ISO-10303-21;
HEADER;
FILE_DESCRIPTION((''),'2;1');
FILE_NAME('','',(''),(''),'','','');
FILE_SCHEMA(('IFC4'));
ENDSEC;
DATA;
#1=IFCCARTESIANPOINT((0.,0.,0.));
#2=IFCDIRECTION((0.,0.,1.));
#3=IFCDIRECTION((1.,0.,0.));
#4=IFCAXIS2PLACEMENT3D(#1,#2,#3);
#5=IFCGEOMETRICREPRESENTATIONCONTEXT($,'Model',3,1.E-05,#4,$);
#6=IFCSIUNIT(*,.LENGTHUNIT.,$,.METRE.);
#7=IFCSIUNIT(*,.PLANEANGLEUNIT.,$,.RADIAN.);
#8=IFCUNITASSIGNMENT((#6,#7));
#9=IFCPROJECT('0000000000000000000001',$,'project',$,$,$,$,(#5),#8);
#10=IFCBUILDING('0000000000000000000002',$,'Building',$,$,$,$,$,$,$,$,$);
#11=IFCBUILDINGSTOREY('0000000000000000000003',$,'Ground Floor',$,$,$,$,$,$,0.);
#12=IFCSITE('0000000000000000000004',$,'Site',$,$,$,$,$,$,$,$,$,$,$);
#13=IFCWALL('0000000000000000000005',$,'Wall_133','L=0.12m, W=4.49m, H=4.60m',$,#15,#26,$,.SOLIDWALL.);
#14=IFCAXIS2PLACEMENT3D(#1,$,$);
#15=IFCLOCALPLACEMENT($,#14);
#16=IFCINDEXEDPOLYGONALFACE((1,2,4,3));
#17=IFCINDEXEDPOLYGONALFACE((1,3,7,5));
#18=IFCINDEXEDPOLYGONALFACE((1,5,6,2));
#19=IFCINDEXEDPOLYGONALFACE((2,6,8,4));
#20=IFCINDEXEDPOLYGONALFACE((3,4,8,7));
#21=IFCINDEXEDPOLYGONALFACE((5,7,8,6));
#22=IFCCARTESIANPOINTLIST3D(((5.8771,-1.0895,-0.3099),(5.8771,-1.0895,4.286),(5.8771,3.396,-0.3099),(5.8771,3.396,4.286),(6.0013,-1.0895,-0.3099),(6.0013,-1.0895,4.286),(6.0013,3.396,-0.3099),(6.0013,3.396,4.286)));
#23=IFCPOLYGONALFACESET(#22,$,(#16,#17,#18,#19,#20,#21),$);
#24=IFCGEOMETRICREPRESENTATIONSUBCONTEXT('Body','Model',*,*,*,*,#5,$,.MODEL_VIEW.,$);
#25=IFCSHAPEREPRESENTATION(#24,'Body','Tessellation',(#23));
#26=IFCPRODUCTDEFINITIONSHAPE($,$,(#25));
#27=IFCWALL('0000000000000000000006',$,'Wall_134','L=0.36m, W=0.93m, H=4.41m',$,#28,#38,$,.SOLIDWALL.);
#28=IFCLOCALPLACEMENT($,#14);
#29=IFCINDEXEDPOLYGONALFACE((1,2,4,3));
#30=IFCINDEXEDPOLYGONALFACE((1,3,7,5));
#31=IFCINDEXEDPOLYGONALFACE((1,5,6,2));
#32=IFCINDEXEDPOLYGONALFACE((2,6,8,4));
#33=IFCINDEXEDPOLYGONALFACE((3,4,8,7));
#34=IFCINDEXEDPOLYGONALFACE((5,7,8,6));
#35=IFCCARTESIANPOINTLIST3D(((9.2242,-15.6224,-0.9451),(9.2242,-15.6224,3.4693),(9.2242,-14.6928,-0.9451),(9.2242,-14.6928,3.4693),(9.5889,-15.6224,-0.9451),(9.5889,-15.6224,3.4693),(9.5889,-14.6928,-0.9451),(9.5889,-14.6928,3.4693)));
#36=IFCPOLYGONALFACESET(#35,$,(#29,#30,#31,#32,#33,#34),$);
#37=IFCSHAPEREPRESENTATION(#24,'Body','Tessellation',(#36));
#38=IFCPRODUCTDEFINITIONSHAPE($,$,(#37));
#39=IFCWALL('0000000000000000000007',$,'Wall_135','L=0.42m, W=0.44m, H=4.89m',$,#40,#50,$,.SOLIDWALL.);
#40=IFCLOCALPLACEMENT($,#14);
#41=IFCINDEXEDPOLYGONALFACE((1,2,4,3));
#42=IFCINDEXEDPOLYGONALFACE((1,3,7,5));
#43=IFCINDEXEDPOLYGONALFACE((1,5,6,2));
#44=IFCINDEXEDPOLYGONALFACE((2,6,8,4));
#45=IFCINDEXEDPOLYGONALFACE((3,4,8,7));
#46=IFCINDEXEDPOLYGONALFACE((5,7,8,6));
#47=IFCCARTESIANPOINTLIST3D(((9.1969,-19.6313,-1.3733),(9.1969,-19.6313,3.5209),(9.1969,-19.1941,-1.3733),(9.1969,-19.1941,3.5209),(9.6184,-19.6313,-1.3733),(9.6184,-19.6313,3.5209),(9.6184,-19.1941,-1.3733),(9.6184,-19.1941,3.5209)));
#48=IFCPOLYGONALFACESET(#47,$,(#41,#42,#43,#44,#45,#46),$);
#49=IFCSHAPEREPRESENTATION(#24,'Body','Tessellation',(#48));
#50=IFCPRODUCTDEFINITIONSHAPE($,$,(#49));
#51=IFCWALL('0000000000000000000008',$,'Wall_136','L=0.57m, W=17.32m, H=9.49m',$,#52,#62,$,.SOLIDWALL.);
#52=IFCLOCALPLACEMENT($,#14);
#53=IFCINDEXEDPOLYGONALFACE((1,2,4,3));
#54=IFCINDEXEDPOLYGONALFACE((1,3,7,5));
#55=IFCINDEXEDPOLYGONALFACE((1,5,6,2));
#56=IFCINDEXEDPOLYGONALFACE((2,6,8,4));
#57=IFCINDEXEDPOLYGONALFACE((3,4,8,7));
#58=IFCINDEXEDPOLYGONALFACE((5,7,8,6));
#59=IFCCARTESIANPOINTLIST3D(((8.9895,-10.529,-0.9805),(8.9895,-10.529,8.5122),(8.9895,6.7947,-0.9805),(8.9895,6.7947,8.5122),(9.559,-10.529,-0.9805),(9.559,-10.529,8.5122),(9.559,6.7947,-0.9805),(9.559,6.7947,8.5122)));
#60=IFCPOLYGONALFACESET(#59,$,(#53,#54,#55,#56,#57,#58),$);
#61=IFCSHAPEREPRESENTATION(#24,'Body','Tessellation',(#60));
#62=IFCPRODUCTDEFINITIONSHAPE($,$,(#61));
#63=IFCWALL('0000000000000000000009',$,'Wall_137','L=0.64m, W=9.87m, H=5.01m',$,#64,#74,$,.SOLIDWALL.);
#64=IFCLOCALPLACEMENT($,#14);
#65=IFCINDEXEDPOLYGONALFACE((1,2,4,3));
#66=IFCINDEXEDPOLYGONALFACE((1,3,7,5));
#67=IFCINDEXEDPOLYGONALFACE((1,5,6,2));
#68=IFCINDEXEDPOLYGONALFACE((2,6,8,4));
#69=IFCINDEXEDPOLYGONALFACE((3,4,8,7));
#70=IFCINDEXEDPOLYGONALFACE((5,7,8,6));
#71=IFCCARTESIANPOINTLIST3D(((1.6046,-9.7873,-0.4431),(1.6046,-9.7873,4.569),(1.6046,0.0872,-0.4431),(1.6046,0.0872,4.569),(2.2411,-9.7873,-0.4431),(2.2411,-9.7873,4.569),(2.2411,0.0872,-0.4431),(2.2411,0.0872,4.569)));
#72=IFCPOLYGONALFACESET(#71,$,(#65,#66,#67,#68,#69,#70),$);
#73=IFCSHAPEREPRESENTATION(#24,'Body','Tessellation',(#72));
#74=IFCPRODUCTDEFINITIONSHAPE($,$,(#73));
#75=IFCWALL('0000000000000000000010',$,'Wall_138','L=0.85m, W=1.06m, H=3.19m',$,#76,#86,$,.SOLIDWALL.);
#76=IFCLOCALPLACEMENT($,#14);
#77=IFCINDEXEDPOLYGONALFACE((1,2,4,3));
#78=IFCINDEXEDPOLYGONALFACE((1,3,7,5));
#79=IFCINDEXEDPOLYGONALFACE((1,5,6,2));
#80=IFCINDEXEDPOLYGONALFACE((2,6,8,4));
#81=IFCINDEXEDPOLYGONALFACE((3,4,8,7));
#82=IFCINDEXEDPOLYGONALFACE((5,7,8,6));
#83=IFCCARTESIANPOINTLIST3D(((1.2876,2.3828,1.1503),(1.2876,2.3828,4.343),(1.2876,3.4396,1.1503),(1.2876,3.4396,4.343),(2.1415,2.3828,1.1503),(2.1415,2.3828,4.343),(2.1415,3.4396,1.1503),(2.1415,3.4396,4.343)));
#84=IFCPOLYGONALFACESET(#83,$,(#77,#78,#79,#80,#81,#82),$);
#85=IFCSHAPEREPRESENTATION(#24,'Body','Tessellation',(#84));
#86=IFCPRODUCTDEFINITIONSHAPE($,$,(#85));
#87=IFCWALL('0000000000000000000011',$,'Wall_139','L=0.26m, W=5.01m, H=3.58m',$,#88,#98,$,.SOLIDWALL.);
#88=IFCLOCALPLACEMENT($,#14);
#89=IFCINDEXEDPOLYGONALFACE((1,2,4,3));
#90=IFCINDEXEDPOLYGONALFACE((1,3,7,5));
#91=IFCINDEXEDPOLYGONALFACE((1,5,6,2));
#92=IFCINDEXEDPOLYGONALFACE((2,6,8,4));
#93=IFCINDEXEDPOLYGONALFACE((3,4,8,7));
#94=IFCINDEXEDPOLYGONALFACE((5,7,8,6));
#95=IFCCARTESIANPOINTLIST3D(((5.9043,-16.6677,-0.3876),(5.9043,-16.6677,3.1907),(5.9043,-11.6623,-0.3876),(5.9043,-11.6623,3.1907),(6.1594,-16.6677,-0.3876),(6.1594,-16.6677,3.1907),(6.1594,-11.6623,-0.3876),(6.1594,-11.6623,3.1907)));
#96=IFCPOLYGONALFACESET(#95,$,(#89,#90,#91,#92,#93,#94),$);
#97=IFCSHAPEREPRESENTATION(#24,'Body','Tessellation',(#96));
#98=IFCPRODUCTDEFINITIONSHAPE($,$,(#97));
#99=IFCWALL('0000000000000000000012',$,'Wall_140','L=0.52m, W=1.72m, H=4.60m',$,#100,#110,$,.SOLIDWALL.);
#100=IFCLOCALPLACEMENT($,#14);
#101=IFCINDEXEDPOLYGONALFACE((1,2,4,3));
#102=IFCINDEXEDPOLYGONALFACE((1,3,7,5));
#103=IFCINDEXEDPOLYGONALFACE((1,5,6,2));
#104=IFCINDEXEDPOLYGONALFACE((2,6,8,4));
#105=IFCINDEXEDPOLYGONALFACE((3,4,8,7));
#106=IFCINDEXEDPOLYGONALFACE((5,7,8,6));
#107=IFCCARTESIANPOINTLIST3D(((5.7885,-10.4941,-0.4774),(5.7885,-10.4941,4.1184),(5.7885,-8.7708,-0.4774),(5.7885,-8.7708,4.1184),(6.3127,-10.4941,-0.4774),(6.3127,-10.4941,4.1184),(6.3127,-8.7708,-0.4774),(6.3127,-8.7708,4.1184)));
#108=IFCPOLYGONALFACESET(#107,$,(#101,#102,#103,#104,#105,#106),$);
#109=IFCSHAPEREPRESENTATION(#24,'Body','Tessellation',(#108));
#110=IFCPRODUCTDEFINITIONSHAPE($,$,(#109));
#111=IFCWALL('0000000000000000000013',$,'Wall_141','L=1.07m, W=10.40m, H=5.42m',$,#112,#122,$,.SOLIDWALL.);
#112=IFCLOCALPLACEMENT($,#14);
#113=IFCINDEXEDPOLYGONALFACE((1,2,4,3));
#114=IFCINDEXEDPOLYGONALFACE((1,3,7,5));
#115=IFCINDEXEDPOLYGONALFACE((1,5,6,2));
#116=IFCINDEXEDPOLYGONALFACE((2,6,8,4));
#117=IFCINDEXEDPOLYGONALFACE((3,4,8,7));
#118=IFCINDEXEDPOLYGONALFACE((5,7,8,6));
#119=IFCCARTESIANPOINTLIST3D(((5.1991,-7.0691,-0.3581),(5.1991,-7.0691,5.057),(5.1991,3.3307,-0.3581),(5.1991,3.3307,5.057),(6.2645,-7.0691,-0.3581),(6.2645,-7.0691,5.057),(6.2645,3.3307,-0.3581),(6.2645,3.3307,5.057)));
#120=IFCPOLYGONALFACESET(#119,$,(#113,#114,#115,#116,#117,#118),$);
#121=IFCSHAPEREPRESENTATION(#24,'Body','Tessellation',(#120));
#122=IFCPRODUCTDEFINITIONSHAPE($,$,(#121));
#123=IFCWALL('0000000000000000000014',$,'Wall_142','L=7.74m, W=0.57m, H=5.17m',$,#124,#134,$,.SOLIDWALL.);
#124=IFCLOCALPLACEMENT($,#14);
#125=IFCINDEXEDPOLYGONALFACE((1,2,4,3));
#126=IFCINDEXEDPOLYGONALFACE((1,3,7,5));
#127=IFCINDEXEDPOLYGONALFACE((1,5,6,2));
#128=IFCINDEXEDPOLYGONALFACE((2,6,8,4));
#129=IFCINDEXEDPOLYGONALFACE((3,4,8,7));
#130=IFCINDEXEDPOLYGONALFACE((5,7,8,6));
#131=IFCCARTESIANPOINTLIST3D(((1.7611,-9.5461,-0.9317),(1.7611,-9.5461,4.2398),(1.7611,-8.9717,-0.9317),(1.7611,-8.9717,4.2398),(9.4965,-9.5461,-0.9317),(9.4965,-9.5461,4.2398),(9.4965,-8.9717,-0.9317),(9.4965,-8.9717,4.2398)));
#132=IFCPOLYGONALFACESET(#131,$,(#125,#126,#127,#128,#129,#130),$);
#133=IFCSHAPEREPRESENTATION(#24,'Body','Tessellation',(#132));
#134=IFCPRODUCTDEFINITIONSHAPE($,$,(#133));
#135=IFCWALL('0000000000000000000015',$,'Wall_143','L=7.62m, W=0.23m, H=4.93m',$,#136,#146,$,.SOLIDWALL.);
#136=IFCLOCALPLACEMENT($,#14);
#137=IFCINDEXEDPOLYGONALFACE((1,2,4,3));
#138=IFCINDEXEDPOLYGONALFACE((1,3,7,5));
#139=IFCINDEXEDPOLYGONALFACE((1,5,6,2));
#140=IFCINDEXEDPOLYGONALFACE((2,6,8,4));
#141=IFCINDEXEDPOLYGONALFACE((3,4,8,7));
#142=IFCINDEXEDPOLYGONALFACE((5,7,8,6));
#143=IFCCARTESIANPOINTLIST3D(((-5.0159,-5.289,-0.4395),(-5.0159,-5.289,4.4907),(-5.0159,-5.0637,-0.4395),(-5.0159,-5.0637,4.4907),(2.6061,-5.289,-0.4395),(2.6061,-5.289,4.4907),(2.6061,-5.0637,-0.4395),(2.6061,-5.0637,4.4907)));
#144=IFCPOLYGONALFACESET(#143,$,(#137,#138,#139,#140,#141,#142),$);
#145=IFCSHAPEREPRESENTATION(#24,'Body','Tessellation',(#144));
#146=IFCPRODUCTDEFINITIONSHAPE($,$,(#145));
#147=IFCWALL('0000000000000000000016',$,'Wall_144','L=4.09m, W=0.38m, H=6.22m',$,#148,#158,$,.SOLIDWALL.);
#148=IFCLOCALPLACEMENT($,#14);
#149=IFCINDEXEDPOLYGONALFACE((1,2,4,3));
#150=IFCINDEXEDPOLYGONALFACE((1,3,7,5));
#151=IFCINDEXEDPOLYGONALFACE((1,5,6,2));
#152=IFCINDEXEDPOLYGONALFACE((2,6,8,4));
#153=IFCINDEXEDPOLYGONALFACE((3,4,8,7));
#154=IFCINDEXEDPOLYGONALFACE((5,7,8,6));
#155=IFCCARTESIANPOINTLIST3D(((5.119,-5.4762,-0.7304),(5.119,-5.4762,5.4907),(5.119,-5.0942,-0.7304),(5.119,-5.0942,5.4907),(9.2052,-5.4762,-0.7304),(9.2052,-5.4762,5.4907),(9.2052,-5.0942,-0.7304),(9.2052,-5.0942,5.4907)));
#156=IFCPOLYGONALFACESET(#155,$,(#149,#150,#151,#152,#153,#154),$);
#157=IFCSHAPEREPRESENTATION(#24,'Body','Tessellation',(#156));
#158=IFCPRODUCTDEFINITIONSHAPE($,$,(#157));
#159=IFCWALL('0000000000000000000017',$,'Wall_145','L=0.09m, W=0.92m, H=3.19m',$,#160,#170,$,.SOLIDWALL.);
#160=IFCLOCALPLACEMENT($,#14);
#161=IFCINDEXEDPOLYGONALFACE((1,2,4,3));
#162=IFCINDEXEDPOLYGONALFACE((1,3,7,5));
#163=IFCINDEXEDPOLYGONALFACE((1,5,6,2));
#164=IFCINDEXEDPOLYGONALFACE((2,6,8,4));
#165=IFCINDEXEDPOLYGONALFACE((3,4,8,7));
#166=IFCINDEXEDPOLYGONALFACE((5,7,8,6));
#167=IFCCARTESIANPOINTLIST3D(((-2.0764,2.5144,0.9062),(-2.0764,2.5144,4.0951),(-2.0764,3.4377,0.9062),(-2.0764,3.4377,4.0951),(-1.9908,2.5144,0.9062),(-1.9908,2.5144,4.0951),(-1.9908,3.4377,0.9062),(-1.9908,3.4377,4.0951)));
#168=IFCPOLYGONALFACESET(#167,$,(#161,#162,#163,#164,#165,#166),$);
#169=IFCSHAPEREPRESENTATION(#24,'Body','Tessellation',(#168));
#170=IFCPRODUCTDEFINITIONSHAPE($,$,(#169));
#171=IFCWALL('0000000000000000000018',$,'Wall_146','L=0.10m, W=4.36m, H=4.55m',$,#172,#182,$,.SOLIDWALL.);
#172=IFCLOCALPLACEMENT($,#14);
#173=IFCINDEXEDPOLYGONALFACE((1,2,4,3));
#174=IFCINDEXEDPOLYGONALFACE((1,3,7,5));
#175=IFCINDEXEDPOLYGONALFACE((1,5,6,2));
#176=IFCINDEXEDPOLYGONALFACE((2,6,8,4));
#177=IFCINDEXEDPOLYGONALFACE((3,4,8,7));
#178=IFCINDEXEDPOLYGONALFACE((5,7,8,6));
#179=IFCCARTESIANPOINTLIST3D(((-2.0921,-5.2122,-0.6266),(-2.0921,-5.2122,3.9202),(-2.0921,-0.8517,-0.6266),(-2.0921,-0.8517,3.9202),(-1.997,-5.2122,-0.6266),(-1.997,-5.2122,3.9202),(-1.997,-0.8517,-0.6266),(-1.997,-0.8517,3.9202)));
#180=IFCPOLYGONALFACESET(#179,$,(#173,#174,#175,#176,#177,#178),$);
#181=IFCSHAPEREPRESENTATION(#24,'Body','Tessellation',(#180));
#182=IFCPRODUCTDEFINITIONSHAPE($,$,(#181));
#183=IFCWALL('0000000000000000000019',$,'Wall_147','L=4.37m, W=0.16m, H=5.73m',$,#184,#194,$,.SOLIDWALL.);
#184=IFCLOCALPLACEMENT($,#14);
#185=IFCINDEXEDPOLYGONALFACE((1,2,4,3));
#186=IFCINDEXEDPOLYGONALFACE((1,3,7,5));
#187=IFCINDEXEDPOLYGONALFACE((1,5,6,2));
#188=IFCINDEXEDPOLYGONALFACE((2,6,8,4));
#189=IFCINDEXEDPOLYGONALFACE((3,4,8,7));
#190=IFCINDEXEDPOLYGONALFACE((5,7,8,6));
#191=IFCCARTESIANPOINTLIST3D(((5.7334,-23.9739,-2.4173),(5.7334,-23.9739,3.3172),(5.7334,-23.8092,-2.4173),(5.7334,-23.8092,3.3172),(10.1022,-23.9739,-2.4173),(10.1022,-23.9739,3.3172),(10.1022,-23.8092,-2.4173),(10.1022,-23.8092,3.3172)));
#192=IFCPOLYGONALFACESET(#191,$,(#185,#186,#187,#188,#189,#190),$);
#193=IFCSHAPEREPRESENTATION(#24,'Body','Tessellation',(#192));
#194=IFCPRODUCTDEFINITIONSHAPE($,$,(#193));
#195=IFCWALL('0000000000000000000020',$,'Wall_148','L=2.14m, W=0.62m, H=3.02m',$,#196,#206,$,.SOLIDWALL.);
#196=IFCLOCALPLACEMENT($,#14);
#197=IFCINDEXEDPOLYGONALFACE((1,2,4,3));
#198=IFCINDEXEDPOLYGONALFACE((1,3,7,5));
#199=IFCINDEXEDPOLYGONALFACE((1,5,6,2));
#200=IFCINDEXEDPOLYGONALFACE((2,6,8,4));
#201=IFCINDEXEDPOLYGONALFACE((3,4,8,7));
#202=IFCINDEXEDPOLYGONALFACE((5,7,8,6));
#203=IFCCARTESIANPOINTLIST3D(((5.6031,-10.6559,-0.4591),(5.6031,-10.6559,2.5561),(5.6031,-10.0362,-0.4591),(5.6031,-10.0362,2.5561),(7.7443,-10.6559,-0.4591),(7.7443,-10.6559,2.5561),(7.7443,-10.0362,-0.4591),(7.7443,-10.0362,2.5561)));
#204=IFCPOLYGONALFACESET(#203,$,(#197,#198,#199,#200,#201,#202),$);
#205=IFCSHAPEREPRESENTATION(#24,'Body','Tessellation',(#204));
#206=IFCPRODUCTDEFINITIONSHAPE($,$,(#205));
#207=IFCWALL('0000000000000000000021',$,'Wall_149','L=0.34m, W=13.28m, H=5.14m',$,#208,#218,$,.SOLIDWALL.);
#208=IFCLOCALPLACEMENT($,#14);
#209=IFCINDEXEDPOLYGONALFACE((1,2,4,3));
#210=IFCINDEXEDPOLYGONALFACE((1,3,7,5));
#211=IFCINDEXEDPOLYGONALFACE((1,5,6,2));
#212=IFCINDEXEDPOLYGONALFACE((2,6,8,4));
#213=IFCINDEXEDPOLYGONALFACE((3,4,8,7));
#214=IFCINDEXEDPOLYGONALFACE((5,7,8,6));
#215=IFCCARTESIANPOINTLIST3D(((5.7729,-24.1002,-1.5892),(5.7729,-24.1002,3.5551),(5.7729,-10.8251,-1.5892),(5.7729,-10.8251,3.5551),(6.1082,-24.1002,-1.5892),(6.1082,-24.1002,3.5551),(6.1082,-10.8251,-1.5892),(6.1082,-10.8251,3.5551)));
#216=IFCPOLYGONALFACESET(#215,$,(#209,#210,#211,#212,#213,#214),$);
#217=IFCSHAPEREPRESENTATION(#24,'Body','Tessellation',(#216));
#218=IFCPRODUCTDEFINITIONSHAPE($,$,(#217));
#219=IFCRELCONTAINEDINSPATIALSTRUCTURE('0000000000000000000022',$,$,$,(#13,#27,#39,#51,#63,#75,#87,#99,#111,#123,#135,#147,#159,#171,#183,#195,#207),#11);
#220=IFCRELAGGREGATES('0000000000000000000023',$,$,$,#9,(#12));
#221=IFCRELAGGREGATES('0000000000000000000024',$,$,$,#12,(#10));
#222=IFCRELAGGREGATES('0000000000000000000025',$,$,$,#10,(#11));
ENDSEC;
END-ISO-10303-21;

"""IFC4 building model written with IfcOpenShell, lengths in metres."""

from ifc_helpers import new_model, si_unit, frame, origin_with_axes, origin_2d, context, subcontext, project, spatial, rectangle, extrude, element, save


model = new_model("IFC4")

# Units and contexts
model_context = context("Model", 3, precision=1e-05, world=origin_with_axes())
body_context = subcontext(model_context, "Body", "Model", "MODEL_VIEW")
ifc_project = project(units=[si_unit("LENGTHUNIT", "METRE"), si_unit("PLANEANGLEUNIT", "RADIAN")], contexts=[model_context])

# Site, building, storey
site = spatial("IfcSite", under=ifc_project, Name="Site")
building = spatial("IfcBuilding", under=site, Name="Building")
storey = spatial("IfcBuildingStorey", under=building, Name="Ground Floor", Elevation=0.0)

# Walls
element("IfcWall", 1, inside=storey, Name="Wall_133", Description="L=0.12m, W=4.49m, H=4.60m", PredefinedType="SOLIDWALL", context=body_context, shape_type="SweptSolid", body=[
    extrude(rectangle(XDim=0.1242, YDim=4.4854, at=origin_2d()), frame((5.9392, 1.1533, -0.3099), z_axis=(0.0, 0.0, 1.0), x_axis=(1.0, 0.0, 0.0)), (0.0, 0.0, 1.0), 4.5959),
])
element("IfcWall", 2, inside=storey, Name="Wall_134", Description="L=0.36m, W=0.93m, H=4.41m", PredefinedType="SOLIDWALL", context=body_context, shape_type="SweptSolid", body=[
    extrude(rectangle(XDim=0.3647, YDim=0.9296, at=origin_2d()), frame((9.4065, -15.1576, -0.9451), z_axis=(0.0, 0.0, 1.0), x_axis=(1.0, 0.0, 0.0)), (0.0, 0.0, 1.0), 4.4145),
])
element("IfcWall", 3, inside=storey, Name="Wall_135", Description="L=0.42m, W=0.44m, H=4.89m", PredefinedType="SOLIDWALL", context=body_context, shape_type="SweptSolid", body=[
    extrude(rectangle(XDim=0.4215, YDim=0.4372, at=origin_2d()), frame((9.4076, -19.4127, -1.3733), z_axis=(0.0, 0.0, 1.0), x_axis=(1.0, 0.0, 0.0)), (0.0, 0.0, 1.0), 4.8942),
])
element("IfcWall", 4, inside=storey, Name="Wall_136", Description="L=0.57m, W=17.32m, H=9.49m", PredefinedType="SOLIDWALL", context=body_context, shape_type="SweptSolid", body=[
    extrude(rectangle(XDim=0.5695, YDim=17.3237, at=origin_2d()), frame((9.2742, -1.8671, -0.9805), z_axis=(0.0, 0.0, 1.0), x_axis=(1.0, 0.0, 0.0)), (0.0, 0.0, 1.0), 9.4927),
])
element("IfcWall", 5, inside=storey, Name="Wall_137", Description="L=0.64m, W=9.87m, H=5.01m", PredefinedType="SOLIDWALL", context=body_context, shape_type="SweptSolid", body=[
    extrude(rectangle(XDim=0.6365, YDim=9.8745, at=origin_2d()), frame((1.9229, -4.8501, -0.4431), z_axis=(0.0, 0.0, 1.0), x_axis=(1.0, 0.0, 0.0)), (0.0, 0.0, 1.0), 5.0121),
])
element("IfcWall", 6, inside=storey, Name="Wall_138", Description="L=0.85m, W=1.06m, H=3.19m", PredefinedType="SOLIDWALL", context=body_context, shape_type="SweptSolid", body=[
    extrude(rectangle(XDim=0.8539, YDim=1.0568, at=origin_2d()), frame((1.7145, 2.9112, 1.1503), z_axis=(0.0, 0.0, 1.0), x_axis=(1.0, 0.0, 0.0)), (0.0, 0.0, 1.0), 3.1927),
])
element("IfcWall", 7, inside=storey, Name="Wall_139", Description="L=0.26m, W=5.01m, H=3.58m", PredefinedType="SOLIDWALL", context=body_context, shape_type="SweptSolid", body=[
    extrude(rectangle(XDim=0.255, YDim=5.0054, at=origin_2d()), frame((6.0319, -14.165, -0.3876), z_axis=(0.0, 0.0, 1.0), x_axis=(1.0, 0.0, 0.0)), (0.0, 0.0, 1.0), 3.5783),
])
element("IfcWall", 8, inside=storey, Name="Wall_140", Description="L=0.52m, W=1.72m, H=4.60m", PredefinedType="SOLIDWALL", context=body_context, shape_type="SweptSolid", body=[
    extrude(rectangle(XDim=0.5242, YDim=1.7233, at=origin_2d()), frame((6.0506, -9.6325, -0.4774), z_axis=(0.0, 0.0, 1.0), x_axis=(1.0, 0.0, 0.0)), (0.0, 0.0, 1.0), 4.5957),
])
element("IfcWall", 9, inside=storey, Name="Wall_141", Description="L=1.07m, W=10.40m, H=5.42m", PredefinedType="SOLIDWALL", context=body_context, shape_type="SweptSolid", body=[
    extrude(rectangle(XDim=1.0655, YDim=10.3998, at=origin_2d()), frame((5.7318, -1.8692, -0.3581), z_axis=(0.0, 0.0, 1.0), x_axis=(1.0, 0.0, 0.0)), (0.0, 0.0, 1.0), 5.415),
])
element("IfcWall", 10, inside=storey, Name="Wall_142", Description="L=7.74m, W=0.57m, H=5.17m", PredefinedType="SOLIDWALL", context=body_context, shape_type="SweptSolid", body=[
    extrude(rectangle(XDim=7.7353, YDim=0.5744, at=origin_2d()), frame((5.6288, -9.2589, -0.9317), z_axis=(0.0, 0.0, 1.0), x_axis=(1.0, 0.0, 0.0)), (0.0, 0.0, 1.0), 5.1715),
])
element("IfcWall", 11, inside=storey, Name="Wall_143", Description="L=7.62m, W=0.23m, H=4.93m", PredefinedType="SOLIDWALL", context=body_context, shape_type="SweptSolid", body=[
    extrude(rectangle(XDim=7.622, YDim=0.2253, at=origin_2d()), frame((-1.2049, -5.1763, -0.4395), z_axis=(0.0, 0.0, 1.0), x_axis=(1.0, 0.0, 0.0)), (0.0, 0.0, 1.0), 4.9302),
])
element("IfcWall", 12, inside=storey, Name="Wall_144", Description="L=4.09m, W=0.38m, H=6.22m", PredefinedType="SOLIDWALL", context=body_context, shape_type="SweptSolid", body=[
    extrude(rectangle(XDim=4.0862, YDim=0.382, at=origin_2d()), frame((7.1621, -5.2852, -0.7304), z_axis=(0.0, 0.0, 1.0), x_axis=(1.0, 0.0, 0.0)), (0.0, 0.0, 1.0), 6.221),
])
element("IfcWall", 13, inside=storey, Name="Wall_145", Description="L=0.09m, W=0.92m, H=3.19m", PredefinedType="SOLIDWALL", context=body_context, shape_type="SweptSolid", body=[
    extrude(rectangle(XDim=0.0856, YDim=0.9233, at=origin_2d()), frame((-2.0336, 2.9761, 0.9062), z_axis=(0.0, 0.0, 1.0), x_axis=(1.0, 0.0, 0.0)), (0.0, 0.0, 1.0), 3.1889),
])
element("IfcWall", 14, inside=storey, Name="Wall_146", Description="L=0.10m, W=4.36m, H=4.55m", PredefinedType="SOLIDWALL", context=body_context, shape_type="SweptSolid", body=[
    extrude(rectangle(XDim=0.0952, YDim=4.3605, at=origin_2d()), frame((-2.0445, -3.0319, -0.6266), z_axis=(0.0, 0.0, 1.0), x_axis=(1.0, 0.0, 0.0)), (0.0, 0.0, 1.0), 4.5468),
])
element("IfcWall", 15, inside=storey, Name="Wall_147", Description="L=4.37m, W=0.16m, H=5.73m", PredefinedType="SOLIDWALL", context=body_context, shape_type="SweptSolid", body=[
    extrude(rectangle(XDim=4.3689, YDim=0.1647, at=origin_2d()), frame((7.9178, -23.8915, -2.4173), z_axis=(0.0, 0.0, 1.0), x_axis=(1.0, 0.0, 0.0)), (0.0, 0.0, 1.0), 5.7345),
])
element("IfcWall", 16, inside=storey, Name="Wall_148", Description="L=2.14m, W=0.62m, H=3.02m", PredefinedType="SOLIDWALL", context=body_context, shape_type="SweptSolid", body=[
    extrude(rectangle(XDim=2.1412, YDim=0.6196, at=origin_2d()), frame((6.6737, -10.3461, -0.4591), z_axis=(0.0, 0.0, 1.0), x_axis=(1.0, 0.0, 0.0)), (0.0, 0.0, 1.0), 3.0152),
])
element("IfcWall", 17, inside=storey, Name="Wall_149", Description="L=0.34m, W=13.28m, H=5.14m", PredefinedType="SOLIDWALL", context=body_context, shape_type="SweptSolid", body=[
    extrude(rectangle(XDim=0.3353, YDim=13.2751, at=origin_2d()), frame((5.9405, -17.4627, -1.5892), z_axis=(0.0, 0.0, 1.0), x_axis=(1.0, 0.0, 0.0)), (0.0, 0.0, 1.0), 5.1443),
])

save(model, "model.ifc")
